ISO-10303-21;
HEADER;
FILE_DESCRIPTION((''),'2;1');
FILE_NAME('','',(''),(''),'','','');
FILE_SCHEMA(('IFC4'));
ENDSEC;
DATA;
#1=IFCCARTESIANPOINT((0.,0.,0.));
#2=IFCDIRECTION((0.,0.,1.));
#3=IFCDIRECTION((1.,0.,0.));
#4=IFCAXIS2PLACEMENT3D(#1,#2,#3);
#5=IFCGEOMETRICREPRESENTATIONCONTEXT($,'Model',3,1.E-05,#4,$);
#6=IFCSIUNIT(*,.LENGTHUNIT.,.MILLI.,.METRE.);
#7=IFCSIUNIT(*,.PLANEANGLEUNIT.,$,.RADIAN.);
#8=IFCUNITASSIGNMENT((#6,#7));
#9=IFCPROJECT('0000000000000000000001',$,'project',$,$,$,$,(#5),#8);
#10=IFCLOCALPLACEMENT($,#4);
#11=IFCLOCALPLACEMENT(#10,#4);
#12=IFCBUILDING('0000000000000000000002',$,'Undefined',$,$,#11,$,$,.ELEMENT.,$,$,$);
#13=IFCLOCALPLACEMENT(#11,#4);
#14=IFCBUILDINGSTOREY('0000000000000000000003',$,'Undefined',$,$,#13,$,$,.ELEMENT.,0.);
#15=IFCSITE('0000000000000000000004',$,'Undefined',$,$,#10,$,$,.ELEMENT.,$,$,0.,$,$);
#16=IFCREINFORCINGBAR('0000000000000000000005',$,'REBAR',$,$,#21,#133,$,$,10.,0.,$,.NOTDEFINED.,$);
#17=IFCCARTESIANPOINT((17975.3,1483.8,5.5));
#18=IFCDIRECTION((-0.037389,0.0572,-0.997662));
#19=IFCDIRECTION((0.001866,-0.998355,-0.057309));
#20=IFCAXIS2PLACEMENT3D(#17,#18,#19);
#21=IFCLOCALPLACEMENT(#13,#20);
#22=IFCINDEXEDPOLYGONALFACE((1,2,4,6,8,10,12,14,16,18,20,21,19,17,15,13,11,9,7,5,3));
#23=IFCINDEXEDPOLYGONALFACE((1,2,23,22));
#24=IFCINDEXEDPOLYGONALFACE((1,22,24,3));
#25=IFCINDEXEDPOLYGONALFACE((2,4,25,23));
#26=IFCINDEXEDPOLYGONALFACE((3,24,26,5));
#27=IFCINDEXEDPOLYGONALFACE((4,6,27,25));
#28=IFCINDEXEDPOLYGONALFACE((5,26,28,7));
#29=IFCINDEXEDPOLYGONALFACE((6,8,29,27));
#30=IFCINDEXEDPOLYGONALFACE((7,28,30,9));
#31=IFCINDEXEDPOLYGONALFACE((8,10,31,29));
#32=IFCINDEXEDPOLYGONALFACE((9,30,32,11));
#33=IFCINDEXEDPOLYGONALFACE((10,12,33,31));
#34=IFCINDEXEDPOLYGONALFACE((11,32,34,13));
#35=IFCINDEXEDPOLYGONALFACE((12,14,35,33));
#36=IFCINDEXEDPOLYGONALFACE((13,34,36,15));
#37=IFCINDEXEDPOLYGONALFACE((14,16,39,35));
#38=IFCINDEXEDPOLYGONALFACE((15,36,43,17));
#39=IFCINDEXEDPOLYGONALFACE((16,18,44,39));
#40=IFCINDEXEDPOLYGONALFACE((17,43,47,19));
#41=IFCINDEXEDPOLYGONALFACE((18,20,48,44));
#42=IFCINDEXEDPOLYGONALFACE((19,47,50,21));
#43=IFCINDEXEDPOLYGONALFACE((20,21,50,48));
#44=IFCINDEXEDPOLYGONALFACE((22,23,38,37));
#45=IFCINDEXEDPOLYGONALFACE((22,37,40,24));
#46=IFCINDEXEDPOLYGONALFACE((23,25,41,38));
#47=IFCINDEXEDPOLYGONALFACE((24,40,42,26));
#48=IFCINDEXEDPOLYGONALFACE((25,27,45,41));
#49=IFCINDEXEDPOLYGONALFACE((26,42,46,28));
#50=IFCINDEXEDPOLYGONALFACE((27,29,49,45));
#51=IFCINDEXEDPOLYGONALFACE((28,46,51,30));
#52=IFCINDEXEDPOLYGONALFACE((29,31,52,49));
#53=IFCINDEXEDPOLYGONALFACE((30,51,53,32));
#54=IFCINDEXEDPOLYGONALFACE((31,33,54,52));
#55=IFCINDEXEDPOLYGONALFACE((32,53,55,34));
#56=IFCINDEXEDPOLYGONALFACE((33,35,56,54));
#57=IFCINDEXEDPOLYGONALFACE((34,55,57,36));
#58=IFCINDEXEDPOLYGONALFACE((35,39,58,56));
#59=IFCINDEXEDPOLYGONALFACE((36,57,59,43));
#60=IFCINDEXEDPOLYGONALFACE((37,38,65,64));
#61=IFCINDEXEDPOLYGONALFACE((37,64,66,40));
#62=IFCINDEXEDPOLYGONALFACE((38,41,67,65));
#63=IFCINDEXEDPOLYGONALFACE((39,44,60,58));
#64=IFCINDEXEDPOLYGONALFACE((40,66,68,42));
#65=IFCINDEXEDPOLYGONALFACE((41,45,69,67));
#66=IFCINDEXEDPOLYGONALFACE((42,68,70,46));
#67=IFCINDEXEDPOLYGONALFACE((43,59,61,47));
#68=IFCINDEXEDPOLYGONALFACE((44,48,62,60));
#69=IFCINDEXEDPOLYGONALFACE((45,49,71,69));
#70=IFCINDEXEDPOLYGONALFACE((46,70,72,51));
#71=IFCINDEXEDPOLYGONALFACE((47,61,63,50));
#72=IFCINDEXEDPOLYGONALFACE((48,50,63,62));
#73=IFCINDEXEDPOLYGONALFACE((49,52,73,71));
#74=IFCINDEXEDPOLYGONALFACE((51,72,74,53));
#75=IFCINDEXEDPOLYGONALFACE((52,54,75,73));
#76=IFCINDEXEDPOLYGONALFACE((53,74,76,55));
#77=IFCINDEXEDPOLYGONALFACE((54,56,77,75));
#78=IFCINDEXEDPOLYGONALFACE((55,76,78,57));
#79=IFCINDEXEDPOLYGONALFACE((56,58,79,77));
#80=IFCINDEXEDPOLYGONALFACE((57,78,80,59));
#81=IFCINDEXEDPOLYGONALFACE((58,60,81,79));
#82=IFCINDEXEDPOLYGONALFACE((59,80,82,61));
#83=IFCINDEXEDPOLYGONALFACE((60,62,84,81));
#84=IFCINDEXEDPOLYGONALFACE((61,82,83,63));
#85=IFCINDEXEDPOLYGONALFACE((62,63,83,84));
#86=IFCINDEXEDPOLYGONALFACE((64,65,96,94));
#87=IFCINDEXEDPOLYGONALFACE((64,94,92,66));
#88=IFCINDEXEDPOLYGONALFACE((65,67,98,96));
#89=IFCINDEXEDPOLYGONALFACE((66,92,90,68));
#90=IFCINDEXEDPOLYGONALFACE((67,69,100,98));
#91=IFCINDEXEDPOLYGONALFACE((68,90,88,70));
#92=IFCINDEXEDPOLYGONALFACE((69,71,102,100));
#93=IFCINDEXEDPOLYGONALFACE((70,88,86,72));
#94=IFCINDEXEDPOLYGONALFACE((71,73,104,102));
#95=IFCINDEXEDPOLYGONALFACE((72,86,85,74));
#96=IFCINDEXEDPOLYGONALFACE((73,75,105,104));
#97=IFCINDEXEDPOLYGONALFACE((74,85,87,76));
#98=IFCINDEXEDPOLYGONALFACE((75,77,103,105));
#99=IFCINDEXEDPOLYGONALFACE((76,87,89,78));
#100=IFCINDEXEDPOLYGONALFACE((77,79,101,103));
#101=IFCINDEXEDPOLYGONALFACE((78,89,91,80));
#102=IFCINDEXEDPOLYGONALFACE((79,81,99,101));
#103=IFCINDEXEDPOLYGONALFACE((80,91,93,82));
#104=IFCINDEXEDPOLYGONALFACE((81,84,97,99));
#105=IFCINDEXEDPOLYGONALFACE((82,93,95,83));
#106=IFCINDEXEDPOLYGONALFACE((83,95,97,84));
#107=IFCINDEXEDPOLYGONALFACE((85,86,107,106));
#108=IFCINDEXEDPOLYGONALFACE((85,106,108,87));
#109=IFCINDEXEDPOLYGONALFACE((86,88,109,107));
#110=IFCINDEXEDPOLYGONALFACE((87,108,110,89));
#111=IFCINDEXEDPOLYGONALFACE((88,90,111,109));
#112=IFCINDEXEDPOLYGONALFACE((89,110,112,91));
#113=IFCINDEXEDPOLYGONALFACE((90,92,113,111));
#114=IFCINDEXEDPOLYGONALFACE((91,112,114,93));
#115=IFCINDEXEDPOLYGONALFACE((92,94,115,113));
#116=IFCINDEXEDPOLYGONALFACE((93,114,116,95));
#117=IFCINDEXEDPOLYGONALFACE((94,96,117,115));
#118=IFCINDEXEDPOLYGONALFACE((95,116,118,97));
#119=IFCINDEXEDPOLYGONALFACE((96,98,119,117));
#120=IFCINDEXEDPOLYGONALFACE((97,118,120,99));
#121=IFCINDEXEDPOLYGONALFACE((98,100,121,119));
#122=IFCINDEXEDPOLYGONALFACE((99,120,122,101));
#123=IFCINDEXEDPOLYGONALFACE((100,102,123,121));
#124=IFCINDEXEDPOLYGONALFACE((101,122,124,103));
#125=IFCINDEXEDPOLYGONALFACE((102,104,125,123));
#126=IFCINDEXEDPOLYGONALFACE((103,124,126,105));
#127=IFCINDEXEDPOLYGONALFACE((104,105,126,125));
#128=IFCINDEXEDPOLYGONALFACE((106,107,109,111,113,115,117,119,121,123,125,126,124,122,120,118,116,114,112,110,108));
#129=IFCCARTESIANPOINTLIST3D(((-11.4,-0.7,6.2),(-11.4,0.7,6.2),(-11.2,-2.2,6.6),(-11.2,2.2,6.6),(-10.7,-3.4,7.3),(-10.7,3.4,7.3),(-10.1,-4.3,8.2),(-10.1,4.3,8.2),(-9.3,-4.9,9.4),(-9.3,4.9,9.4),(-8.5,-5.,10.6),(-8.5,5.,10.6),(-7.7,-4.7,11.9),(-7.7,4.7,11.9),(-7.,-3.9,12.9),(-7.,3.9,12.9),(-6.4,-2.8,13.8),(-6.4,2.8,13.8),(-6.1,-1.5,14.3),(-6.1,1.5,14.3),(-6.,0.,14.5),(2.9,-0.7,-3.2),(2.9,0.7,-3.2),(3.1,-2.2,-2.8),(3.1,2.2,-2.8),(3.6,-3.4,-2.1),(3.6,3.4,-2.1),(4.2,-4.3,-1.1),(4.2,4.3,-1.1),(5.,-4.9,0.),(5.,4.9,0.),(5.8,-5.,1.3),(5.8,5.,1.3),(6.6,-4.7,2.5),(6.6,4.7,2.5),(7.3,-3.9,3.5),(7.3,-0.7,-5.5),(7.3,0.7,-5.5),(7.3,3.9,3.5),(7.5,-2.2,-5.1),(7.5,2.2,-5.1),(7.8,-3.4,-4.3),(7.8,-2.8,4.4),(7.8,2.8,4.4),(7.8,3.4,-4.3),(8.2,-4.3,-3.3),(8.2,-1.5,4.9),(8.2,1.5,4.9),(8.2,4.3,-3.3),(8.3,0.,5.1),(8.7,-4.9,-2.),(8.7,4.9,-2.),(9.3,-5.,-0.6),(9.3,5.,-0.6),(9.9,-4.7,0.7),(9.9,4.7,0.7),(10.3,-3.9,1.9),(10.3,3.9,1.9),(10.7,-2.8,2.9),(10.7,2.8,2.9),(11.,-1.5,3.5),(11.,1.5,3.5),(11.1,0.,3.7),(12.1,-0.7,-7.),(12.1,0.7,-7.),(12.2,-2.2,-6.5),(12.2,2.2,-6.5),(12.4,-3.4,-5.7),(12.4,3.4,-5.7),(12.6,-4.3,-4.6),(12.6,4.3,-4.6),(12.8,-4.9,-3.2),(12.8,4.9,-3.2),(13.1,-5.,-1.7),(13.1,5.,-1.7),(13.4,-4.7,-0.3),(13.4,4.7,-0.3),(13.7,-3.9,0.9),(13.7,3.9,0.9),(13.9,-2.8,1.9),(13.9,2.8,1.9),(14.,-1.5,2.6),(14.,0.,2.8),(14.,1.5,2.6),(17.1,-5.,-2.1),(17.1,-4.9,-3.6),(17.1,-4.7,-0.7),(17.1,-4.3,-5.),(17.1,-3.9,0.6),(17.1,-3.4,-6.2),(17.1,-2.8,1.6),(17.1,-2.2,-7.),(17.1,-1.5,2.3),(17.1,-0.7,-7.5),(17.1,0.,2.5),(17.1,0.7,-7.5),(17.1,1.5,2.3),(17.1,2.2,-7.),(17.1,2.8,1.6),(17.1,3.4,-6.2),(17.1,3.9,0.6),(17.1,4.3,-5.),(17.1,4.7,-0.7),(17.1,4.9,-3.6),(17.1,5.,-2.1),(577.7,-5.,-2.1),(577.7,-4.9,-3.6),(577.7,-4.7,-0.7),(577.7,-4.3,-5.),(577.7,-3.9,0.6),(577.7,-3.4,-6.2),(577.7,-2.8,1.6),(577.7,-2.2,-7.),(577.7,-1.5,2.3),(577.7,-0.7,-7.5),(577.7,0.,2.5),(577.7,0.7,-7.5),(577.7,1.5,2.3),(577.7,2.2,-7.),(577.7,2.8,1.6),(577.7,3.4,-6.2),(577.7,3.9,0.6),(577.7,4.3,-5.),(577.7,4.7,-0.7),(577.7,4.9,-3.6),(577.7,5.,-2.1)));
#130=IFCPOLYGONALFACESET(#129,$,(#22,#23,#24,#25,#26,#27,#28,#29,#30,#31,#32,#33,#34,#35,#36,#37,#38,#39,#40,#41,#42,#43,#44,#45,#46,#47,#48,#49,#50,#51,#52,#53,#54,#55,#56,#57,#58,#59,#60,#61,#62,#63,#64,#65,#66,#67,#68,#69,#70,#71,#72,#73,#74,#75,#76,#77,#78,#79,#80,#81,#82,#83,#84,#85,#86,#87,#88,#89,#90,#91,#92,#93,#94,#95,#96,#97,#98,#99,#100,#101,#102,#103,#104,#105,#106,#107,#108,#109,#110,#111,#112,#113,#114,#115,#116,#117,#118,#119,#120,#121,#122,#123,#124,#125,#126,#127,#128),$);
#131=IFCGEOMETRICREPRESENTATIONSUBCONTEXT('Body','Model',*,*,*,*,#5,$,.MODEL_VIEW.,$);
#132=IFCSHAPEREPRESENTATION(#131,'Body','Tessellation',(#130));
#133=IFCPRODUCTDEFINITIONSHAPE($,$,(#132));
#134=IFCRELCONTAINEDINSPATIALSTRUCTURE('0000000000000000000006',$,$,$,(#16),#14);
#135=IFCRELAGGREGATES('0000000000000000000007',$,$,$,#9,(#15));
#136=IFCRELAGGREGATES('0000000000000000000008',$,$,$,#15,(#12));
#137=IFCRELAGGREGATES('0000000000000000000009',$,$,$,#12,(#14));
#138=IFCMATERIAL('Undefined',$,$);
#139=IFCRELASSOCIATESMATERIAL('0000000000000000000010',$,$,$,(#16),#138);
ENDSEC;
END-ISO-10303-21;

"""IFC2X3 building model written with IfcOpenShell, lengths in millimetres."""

from ifc_helpers import new_model, entity, si_unit, frame, origin_with_axes, place, context, subcontext, project, spatial, source, transform, mapped, material, element, save


model = new_model("IFC2X3")

# Units and contexts
model_context = context("Model", 3, precision=1e-05, world=origin_with_axes())
body_context = subcontext(model_context, "Body", "Model", "MODEL_VIEW")
ifc_project = project(units=[si_unit("LENGTHUNIT", "METRE", prefix="MILLI"), si_unit("PLANEANGLEUNIT", "RADIAN")], contexts=[model_context])

# Site, building, storey
site_placement = place(None, origin_with_axes())
site = spatial("IfcSite", under=ifc_project, at=site_placement, Name="Undefined", CompositionType="ELEMENT", RefElevation=0.0)
building_placement = place(site_placement, origin_with_axes())
building = spatial("IfcBuilding", under=site, at=building_placement, Name="Undefined", CompositionType="ELEMENT")
storey_placement = place(building_placement, origin_with_axes())
storey = spatial("IfcBuildingStorey", under=building, at=storey_placement, Name="Undefined", CompositionType="ELEMENT", Elevation=0.0)

# Reinforcing bar
ifc_material_1 = material(Name="Undefined")
shared_shape_1 = source(origin_with_axes(), body_context, "Body", "AdvancedSweptSolid", [
    entity("IfcSweptDiskSolid", entity("IfcCompositeCurve", [entity("IfcCompositeCurveSegment", "CONTINUOUS", True, entity("IfcTrimmedCurve", entity("IfcLine", entity("IfcCartesianPoint", [0.0, 0.0, 0.0]), entity("IfcVector", entity("IfcDirection", [0.835483, 0.0, -0.549516]), 1.0)), [entity("IfcParameterValue", 0.0)], [entity("IfcParameterValue", 17.082101)], True, "PARAMETER")), entity("IfcCompositeCurveSegment", "CONTINUOUS", True, entity("IfcTrimmedCurve", entity("IfcCircle", entity("IfcAxis2Placement3D", entity("IfcCartesianPoint", [25.8, 0.0, 8.2]), entity("IfcDirection", [0.0, -1.0, 0.0]), entity("IfcDirection", [-0.549516, 0.0, -0.835483])), 21.0), [entity("IfcParameterValue", 0.0)], [entity("IfcParameterValue", 0.581785)], True, "PARAMETER")), entity("IfcCompositeCurveSegment", "DISCONTINUOUS", True, entity("IfcTrimmedCurve", entity("IfcLine", entity("IfcCartesianPoint", [25.8, 0.0, -12.8]), entity("IfcVector", entity("IfcDirection", [1.0, 0.0, 0.0]), 1.0)), [entity("IfcParameterValue", 0.0)], [entity("IfcParameterValue", 560.593055)], True, "PARAMETER"))], False), 5.0, None, 0.0, 578.3),
])
reinforcing_bar_1_placement = place(storey_placement, frame((17975.3, 1483.8, 5.5), z_axis=(-0.037389, 0.0572, -0.997662), x_axis=(0.001866, -0.998355, -0.057309)))
element("IfcReinforcingBar", 1, at=reinforcing_bar_1_placement, inside=storey, material=ifc_material_1, Name="REBAR", BarRole="NOTDEFINED", CrossSectionArea=0.0, NominalDiameter=10.0, context=body_context, shape_type="MappedRepresentation", body=[
    mapped(shared_shape_1, transform((-8.7, 0.0, 10.3))),
])

save(model, "model.ifc")
